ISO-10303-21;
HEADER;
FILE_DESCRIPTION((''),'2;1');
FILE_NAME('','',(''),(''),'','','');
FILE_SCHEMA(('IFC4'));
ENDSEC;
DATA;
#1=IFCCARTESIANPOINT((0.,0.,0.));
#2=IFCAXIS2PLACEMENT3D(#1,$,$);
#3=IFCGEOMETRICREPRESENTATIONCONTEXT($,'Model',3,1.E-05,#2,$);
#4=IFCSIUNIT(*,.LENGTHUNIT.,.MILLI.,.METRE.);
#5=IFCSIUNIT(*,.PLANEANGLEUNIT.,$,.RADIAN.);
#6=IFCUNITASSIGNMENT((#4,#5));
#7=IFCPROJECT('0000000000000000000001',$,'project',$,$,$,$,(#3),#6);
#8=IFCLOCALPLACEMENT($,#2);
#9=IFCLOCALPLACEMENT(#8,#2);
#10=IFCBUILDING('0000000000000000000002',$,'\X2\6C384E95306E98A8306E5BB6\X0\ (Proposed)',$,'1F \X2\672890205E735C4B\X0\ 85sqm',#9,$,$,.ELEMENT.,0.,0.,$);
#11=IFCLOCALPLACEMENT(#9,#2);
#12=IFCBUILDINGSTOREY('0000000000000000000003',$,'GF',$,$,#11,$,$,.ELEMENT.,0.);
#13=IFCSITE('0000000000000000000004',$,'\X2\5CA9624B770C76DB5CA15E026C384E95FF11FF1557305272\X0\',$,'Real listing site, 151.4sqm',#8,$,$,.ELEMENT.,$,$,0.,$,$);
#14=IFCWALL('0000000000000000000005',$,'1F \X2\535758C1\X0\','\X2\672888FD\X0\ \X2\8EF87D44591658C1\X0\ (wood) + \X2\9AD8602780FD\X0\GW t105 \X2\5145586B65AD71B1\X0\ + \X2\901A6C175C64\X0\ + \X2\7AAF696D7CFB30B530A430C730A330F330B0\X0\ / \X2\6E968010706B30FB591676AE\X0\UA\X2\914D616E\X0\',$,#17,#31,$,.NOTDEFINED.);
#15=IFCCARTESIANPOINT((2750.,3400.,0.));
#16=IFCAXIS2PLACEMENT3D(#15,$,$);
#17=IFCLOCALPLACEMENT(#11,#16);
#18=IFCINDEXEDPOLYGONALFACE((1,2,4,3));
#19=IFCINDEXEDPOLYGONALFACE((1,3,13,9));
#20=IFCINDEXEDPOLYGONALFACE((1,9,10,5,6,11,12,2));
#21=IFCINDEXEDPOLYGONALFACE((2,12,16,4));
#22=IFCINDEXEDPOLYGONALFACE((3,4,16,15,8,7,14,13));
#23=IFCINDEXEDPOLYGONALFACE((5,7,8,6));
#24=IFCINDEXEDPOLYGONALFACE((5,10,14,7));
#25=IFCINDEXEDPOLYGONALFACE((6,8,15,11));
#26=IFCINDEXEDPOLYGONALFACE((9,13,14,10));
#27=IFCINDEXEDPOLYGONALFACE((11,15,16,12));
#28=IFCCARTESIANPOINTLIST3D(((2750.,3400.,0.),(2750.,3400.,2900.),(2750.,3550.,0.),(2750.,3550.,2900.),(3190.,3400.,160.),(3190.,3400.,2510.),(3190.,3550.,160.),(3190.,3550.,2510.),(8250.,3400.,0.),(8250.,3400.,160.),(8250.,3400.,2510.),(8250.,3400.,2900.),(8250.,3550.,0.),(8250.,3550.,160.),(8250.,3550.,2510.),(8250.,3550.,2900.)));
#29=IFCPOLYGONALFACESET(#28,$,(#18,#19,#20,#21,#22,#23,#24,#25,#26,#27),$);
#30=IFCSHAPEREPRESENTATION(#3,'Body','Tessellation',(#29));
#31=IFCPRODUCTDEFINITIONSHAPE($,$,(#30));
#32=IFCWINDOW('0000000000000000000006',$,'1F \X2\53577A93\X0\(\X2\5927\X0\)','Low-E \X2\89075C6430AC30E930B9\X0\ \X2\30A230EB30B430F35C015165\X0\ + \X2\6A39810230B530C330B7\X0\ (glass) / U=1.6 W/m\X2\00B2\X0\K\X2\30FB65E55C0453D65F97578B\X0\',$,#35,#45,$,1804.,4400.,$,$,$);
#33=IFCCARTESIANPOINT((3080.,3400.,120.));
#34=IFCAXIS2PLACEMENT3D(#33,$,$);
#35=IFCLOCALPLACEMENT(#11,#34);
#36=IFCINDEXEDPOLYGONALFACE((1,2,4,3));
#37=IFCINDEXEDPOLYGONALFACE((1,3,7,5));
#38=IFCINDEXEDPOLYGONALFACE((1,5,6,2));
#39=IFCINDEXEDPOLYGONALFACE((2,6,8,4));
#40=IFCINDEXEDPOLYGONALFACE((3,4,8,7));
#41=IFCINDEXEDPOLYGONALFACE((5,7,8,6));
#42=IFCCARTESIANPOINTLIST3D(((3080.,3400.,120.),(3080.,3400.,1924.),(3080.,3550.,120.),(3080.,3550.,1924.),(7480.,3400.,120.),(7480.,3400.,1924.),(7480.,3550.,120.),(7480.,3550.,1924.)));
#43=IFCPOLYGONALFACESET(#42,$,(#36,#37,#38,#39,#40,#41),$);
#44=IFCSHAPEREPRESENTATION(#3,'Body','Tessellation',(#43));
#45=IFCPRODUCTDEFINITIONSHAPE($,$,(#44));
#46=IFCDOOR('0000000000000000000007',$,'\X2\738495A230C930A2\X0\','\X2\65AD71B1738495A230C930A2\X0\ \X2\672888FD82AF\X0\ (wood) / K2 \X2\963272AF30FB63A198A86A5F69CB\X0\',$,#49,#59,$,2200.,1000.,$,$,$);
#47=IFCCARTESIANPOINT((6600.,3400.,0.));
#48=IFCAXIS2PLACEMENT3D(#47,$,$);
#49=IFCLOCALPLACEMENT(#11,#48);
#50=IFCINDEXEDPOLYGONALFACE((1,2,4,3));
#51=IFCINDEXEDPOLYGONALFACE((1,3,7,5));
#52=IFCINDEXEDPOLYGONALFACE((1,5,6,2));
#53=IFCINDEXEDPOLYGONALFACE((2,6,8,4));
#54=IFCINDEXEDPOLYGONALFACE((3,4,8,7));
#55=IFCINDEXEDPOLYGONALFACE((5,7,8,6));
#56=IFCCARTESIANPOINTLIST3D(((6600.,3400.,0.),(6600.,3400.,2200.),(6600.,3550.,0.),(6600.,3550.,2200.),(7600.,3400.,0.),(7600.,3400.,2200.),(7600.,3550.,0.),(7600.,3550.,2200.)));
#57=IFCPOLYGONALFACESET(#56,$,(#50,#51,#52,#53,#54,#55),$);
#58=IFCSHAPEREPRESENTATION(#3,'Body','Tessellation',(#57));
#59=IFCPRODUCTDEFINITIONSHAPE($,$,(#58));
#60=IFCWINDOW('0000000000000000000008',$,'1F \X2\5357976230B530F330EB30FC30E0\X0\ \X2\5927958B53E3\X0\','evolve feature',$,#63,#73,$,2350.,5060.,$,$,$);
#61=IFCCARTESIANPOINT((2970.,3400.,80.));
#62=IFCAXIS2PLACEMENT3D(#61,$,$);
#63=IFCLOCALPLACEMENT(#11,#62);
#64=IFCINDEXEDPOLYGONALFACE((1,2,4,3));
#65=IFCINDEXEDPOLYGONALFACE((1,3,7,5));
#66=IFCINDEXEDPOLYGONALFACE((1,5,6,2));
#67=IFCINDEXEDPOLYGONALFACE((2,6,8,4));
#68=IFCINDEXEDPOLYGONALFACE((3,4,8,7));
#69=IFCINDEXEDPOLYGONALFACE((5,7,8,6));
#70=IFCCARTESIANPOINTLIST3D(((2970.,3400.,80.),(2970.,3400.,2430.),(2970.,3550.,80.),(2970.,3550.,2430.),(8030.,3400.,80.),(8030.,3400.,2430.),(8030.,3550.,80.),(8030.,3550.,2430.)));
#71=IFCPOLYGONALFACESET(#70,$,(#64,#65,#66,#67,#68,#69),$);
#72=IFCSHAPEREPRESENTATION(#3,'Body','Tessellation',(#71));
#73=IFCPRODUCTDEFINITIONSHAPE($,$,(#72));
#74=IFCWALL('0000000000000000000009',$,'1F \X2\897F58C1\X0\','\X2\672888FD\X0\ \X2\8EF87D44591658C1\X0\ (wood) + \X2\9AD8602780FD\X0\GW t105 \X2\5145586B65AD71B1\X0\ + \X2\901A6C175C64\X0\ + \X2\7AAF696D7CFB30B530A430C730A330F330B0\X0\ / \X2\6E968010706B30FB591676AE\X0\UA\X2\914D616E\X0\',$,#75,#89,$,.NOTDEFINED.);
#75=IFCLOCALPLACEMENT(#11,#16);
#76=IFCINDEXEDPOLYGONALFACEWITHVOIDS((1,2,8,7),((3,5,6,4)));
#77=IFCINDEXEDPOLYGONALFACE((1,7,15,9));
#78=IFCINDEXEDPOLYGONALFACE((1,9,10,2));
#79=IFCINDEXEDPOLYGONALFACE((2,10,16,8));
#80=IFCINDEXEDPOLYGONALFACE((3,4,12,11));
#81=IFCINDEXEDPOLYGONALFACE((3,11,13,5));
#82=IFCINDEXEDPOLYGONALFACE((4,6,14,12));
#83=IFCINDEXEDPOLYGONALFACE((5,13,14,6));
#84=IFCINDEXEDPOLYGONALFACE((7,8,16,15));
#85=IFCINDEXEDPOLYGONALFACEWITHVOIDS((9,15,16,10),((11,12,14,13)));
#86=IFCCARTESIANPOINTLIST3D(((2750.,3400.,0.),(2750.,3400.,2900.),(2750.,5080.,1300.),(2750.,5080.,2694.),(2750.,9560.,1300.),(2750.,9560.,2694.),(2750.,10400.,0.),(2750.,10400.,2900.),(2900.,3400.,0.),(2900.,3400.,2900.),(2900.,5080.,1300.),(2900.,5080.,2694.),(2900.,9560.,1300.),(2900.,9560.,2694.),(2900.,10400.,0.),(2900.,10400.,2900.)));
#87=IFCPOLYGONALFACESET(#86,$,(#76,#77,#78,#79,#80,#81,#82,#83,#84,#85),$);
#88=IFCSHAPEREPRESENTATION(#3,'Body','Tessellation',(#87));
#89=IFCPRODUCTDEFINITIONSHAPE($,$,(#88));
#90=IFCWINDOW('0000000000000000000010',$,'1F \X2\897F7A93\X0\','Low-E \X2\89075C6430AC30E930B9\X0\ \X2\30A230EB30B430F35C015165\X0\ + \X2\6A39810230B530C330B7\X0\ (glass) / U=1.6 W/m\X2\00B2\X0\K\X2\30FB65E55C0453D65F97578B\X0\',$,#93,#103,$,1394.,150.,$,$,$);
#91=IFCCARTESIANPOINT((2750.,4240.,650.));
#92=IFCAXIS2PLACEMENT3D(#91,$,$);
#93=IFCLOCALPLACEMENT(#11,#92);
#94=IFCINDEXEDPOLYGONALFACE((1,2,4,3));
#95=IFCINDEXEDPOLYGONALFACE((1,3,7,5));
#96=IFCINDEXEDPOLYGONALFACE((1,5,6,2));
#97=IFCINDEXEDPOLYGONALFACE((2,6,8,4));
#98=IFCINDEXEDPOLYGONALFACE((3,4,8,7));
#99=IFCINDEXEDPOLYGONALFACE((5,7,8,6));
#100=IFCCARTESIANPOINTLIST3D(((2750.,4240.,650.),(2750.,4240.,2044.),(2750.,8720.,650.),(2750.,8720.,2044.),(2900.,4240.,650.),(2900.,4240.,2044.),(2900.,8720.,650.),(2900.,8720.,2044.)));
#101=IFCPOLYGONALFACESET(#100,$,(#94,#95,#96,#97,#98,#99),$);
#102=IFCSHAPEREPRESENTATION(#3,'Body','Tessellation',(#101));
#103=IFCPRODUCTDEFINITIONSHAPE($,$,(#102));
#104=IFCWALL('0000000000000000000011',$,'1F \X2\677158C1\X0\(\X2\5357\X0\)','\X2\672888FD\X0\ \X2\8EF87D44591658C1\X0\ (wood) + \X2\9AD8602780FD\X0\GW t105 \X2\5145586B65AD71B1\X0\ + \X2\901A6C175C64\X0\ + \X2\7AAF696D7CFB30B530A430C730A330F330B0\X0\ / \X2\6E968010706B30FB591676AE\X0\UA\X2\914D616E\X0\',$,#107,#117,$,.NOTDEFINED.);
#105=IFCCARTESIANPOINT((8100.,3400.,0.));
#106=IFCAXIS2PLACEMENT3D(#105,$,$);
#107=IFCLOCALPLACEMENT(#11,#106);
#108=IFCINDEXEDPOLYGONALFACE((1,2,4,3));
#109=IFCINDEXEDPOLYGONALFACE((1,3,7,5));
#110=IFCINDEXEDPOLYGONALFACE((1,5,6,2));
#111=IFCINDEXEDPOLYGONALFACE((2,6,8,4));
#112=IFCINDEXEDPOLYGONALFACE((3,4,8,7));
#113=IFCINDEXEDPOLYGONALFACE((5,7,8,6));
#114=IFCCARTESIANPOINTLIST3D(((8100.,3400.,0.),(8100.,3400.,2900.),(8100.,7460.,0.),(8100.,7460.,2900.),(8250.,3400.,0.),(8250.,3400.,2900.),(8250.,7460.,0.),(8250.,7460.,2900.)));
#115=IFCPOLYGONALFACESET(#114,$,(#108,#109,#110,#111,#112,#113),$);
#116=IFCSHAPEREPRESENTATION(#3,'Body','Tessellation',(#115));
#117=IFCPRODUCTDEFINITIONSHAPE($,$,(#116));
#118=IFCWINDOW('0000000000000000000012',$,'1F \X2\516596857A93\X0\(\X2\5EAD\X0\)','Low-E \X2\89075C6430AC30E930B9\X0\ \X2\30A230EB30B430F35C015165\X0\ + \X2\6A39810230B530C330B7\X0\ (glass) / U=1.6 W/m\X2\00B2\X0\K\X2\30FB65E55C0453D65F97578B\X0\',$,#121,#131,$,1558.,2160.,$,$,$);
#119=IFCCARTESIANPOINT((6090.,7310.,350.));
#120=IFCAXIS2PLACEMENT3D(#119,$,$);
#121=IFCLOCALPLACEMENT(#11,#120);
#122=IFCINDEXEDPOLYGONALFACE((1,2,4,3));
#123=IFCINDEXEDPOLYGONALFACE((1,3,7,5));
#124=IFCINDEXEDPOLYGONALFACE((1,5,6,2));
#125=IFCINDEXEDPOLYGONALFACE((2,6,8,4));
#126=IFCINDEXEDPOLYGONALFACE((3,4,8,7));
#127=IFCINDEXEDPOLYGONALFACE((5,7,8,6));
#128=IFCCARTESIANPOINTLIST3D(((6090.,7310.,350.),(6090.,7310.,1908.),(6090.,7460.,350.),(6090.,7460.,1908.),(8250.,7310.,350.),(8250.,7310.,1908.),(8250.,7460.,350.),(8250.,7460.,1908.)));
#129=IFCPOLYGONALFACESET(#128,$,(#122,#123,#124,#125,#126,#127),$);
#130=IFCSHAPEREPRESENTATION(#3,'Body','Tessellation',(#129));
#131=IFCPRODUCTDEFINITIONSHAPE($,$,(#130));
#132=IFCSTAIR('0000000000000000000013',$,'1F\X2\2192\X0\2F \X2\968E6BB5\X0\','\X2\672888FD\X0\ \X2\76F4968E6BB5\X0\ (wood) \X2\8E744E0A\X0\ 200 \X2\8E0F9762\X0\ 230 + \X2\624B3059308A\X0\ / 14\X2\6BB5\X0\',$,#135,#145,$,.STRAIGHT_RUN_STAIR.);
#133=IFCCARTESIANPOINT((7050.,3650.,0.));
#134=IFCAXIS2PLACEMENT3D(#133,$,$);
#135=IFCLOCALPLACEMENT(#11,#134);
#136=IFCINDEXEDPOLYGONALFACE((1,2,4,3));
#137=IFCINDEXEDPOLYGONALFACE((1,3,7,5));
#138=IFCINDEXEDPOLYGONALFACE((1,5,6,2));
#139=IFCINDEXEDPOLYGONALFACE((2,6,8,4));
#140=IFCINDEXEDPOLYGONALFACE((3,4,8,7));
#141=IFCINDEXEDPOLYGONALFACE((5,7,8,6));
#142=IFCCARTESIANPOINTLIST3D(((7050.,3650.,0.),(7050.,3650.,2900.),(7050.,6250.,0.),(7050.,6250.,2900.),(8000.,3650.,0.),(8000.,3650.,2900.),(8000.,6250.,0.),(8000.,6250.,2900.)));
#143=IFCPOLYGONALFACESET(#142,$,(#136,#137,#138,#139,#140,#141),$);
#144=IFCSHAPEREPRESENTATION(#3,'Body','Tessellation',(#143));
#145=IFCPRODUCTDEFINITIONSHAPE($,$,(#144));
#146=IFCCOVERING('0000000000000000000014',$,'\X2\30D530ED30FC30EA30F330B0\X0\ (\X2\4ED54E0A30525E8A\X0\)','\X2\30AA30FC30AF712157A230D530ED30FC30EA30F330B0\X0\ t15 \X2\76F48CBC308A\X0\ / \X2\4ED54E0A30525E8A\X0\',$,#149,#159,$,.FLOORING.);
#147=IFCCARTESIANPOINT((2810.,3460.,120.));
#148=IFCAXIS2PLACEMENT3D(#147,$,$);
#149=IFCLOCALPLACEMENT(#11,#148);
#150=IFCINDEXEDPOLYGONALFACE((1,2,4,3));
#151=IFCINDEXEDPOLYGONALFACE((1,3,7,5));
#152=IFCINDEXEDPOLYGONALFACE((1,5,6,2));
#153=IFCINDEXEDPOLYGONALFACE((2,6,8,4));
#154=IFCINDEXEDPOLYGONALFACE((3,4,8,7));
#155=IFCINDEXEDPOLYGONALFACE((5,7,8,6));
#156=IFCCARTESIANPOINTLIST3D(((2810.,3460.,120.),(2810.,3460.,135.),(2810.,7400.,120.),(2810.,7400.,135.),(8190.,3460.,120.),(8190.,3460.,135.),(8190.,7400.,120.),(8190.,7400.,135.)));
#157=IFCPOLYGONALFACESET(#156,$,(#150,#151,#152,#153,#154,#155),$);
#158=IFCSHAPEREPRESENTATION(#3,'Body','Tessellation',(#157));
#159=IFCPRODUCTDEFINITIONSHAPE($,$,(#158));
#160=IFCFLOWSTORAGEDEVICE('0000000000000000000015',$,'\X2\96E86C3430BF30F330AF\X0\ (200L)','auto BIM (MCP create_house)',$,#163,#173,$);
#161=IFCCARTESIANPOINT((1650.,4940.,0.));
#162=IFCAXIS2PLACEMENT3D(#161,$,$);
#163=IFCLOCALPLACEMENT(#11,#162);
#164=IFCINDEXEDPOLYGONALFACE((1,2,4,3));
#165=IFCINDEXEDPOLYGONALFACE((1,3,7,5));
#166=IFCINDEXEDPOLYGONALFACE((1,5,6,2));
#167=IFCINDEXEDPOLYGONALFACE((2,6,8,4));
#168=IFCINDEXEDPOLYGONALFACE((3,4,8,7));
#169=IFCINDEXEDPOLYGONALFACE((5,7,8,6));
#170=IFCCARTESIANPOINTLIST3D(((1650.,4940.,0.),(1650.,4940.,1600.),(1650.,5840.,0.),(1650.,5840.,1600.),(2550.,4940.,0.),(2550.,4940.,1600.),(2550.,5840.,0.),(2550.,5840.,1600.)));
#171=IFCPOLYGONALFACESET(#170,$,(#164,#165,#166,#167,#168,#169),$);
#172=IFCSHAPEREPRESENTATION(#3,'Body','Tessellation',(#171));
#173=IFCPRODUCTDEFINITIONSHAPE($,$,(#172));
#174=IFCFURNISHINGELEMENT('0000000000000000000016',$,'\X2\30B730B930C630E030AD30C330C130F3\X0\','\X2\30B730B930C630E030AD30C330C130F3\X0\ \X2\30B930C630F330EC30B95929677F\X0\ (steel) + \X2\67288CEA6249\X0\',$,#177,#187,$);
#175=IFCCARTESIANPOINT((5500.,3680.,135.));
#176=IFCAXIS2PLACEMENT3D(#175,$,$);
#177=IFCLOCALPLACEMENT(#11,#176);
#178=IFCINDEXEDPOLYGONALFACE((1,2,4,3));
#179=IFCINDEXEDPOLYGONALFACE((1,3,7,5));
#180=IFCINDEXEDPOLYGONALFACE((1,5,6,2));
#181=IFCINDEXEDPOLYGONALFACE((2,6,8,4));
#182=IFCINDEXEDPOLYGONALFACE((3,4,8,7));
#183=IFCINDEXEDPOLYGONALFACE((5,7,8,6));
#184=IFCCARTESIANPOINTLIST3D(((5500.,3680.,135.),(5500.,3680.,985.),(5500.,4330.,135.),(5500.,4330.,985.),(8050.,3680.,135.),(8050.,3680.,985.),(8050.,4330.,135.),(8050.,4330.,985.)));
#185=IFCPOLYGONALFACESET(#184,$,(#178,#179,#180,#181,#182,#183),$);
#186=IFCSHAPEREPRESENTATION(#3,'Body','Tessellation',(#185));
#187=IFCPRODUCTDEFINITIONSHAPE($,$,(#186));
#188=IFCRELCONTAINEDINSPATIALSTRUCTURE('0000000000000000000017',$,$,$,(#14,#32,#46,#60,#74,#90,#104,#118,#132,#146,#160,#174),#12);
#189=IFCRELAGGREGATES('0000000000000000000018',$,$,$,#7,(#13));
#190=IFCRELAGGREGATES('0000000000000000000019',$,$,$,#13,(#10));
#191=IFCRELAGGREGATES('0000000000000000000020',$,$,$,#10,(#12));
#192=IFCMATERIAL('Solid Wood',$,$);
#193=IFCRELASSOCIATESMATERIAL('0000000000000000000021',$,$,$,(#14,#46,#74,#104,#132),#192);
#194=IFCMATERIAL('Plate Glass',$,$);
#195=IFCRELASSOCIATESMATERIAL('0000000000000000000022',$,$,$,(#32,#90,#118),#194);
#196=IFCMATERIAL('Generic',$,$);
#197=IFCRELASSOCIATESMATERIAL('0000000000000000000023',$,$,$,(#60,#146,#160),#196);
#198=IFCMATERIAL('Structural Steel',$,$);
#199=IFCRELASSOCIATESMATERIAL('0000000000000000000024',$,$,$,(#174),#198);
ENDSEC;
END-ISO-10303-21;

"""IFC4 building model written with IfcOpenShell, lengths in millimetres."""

from ifc_helpers import new_model, si_unit, frame, frame_2d, origin, place, context, project, spatial, rectangle, extrude, material, element, fill, save


model = new_model("IFC4")

# Units and contexts
model_context = context("Model", 3, precision=1e-05, world=origin())
ifc_project = project(units=[si_unit("LENGTHUNIT", "METRE", prefix="MILLI"), si_unit("PLANEANGLEUNIT", "RADIAN")], contexts=[model_context])

# Site, building, storey
site_placement = place(None, origin())
site = spatial("IfcSite", under=ifc_project, at=site_placement, Name="岩手県盛岡市永井１５地割", ObjectType="Real listing site, 151.4sqm", CompositionType="ELEMENT", RefElevation=0.0)
building_placement = place(site_placement, origin())
building = spatial("IfcBuilding", under=site, at=building_placement, Name="永井の風の家 (Proposed)", ObjectType="1F 木造平屋 85sqm", CompositionType="ELEMENT", ElevationOfRefHeight=0.0, ElevationOfTerrain=0.0)
storey_placement = place(building_placement, origin())
storey = spatial("IfcBuildingStorey", under=building, at=storey_placement, Name="GF", CompositionType="ELEMENT", Elevation=0.0)

# Shared definitions
ifc_material_1 = material(Name="Solid Wood")
ifc_material_2 = material(Name="Generic")

# Wall, openings, windows, door
wall_1_placement = place(storey_placement, frame((2750.0, 3400.0, 0.0)))
wall_1 = element("IfcWall", 1, at=wall_1_placement, inside=storey, material=ifc_material_1, Name="1F 南壁", Description="木製 軸組外壁 (wood) + 高性能GW t105 充填断熱 + 通気層 + 窯業系サイディング / 準耐火・外皮UA配慮", PredefinedType="NOTDEFINED", context=model_context, shape_type="SweptSolid", body=[
    extrude(rectangle(XDim=5500.0, YDim=150.0, at=frame_2d((2750.0, 75.0))), frame((2750.0, 3400.0, 0.0)), (0.0, 0.0, 1.0), 2900.0),
])
opening_1_placement = place(storey_placement, frame((3080.0, 3400.0, 120.0)))
opening_1 = element("IfcOpeningElement", 2, at=opening_1_placement, cuts=wall_1, PredefinedType="NOTDEFINED", context=model_context, shape_type="SweptSolid", body=[
    extrude(rectangle(XDim=4400.0, YDim=150.0, at=frame_2d((2200.0, 75.0))), frame((3080.0, 3400.0, 120.0)), (0.0, 0.0, 1.0), 1804.0),
])
opening_2_placement = place(storey_placement, frame((6600.0, 3400.0, 0.0)))
opening_2 = element("IfcOpeningElement", 3, at=opening_2_placement, cuts=wall_1, PredefinedType="NOTDEFINED", context=model_context, shape_type="SweptSolid", body=[
    extrude(rectangle(XDim=1000.0, YDim=150.0, at=frame_2d((500.0, 75.0))), frame((6600.0, 3400.0, 0.0)), (0.0, 0.0, 1.0), 2200.0),
])
opening_3_placement = place(storey_placement, frame((2970.0, 3400.0, 80.0)))
opening_3 = element("IfcOpeningElement", 4, at=opening_3_placement, cuts=wall_1, PredefinedType="NOTDEFINED", context=model_context, shape_type="SweptSolid", body=[
    extrude(rectangle(XDim=5060.0, YDim=150.0, at=frame_2d((2530.0, 75.0))), frame((2970.0, 3400.0, 80.0)), (0.0, 0.0, 1.0), 2350.0),
])
ifc_material_3 = material(Name="Plate Glass")
window_1_placement = place(storey_placement, frame((3080.0, 3400.0, 120.0)))
window_1 = element("IfcWindow", 5, at=window_1_placement, inside=storey, material=ifc_material_3, Name="1F 南窓(大)", Description="Low-E 複層ガラス アルゴン封入 + 樹脂サッシ (glass) / U=1.6 W/m²K・日射取得型", OverallHeight=1804.0, OverallWidth=4400.0, context=model_context, shape_type="SweptSolid", body=[
    extrude(rectangle(XDim=4400.0, YDim=150.0, at=frame_2d((2200.0, 75.0))), frame((3080.0, 3400.0, 120.0)), (0.0, 0.0, 1.0), 1804.0),
])
fill(opening_1, window_1)
door_1_placement = place(storey_placement, frame((6600.0, 3400.0, 0.0)))
door_1 = element("IfcDoor", 6, at=door_1_placement, inside=storey, material=ifc_material_1, Name="玄関ドア", Description="断熱玄関ドア 木製芯 (wood) / K2 防犯・採風機構", OverallHeight=2200.0, OverallWidth=1000.0, context=model_context, shape_type="SweptSolid", body=[
    extrude(rectangle(XDim=1000.0, YDim=150.0, at=frame_2d((500.0, 75.0))), frame((6600.0, 3400.0, 0.0)), (0.0, 0.0, 1.0), 2200.0),
])
fill(opening_2, door_1)
window_2_placement = place(storey_placement, frame((2970.0, 3400.0, 80.0)))
window_2 = element("IfcWindow", 7, at=window_2_placement, inside=storey, material=ifc_material_2, Name="1F 南面サンルーム 大開口", Description="evolve feature", OverallHeight=2350.0, OverallWidth=5060.0, context=model_context, shape_type="SweptSolid", body=[
    extrude(rectangle(XDim=5060.0, YDim=150.0, at=frame_2d((2530.0, 75.0))), frame((2970.0, 3400.0, 80.0)), (0.0, 0.0, 1.0), 2350.0),
])
fill(opening_3, window_2)

# Walls, openings, windows
wall_2_placement = place(storey_placement, frame((2750.0, 3400.0, 0.0)))
wall_2 = element("IfcWall", 8, at=wall_2_placement, inside=storey, material=ifc_material_1, Name="1F 西壁", Description="木製 軸組外壁 (wood) + 高性能GW t105 充填断熱 + 通気層 + 窯業系サイディング / 準耐火・外皮UA配慮", PredefinedType="NOTDEFINED", context=model_context, shape_type="SweptSolid", body=[
    extrude(rectangle(XDim=150.0, YDim=7000.0, at=frame_2d((75.0, 3500.0))), frame((2750.0, 3400.0, 0.0)), (0.0, 0.0, 1.0), 2900.0),
])
opening_4_placement = place(storey_placement, frame((2750.0, 4240.0, 650.0)))
opening_4 = element("IfcOpeningElement", 9, at=opening_4_placement, cuts=wall_2, PredefinedType="NOTDEFINED", context=model_context, shape_type="SweptSolid", body=[
    extrude(rectangle(XDim=150.0, YDim=4480.0, at=frame_2d((75.0, 2240.0))), frame((2750.0, 4240.0, 650.0)), (0.0, 0.0, 1.0), 1394.0),
])
window_3_placement = place(storey_placement, frame((2750.0, 4240.0, 650.0)))
window_3 = element("IfcWindow", 10, at=window_3_placement, inside=storey, material=ifc_material_3, Name="1F 西窓", Description="Low-E 複層ガラス アルゴン封入 + 樹脂サッシ (glass) / U=1.6 W/m²K・日射取得型", OverallHeight=1394.0, OverallWidth=150.0, context=model_context, shape_type="SweptSolid", body=[
    extrude(rectangle(XDim=150.0, YDim=4480.0, at=frame_2d((75.0, 2240.0))), frame((2750.0, 4240.0, 650.0)), (0.0, 0.0, 1.0), 1394.0),
])
fill(opening_4, window_3)
wall_3_placement = place(storey_placement, frame((8100.0, 3400.0, 0.0)))
wall_3 = element("IfcWall", 11, at=wall_3_placement, inside=storey, material=ifc_material_1, Name="1F 東壁(南)", Description="木製 軸組外壁 (wood) + 高性能GW t105 充填断熱 + 通気層 + 窯業系サイディング / 準耐火・外皮UA配慮", PredefinedType="NOTDEFINED", context=model_context, shape_type="SweptSolid", body=[
    extrude(rectangle(XDim=150.0, YDim=4060.0, at=frame_2d((75.0, 2030.0))), frame((8100.0, 3400.0, 0.0)), (0.0, 0.0, 1.0), 2900.0),
])
opening_5_placement = place(storey_placement, frame((6090.0, 7310.0, 350.0)))
opening_5 = element("IfcOpeningElement", 12, at=opening_5_placement, cuts=wall_3, PredefinedType="NOTDEFINED", context=model_context, shape_type="SweptSolid", body=[
    extrude(rectangle(XDim=2160.0, YDim=150.0, at=frame_2d((1080.0, 75.0))), frame((6090.0, 7310.0, 350.0)), (0.0, 0.0, 1.0), 1558.0),
])
window_4_placement = place(storey_placement, frame((6090.0, 7310.0, 350.0)))
window_4 = element("IfcWindow", 13, at=window_4_placement, inside=storey, material=ifc_material_3, Name="1F 入隅窓(庭)", Description="Low-E 複層ガラス アルゴン封入 + 樹脂サッシ (glass) / U=1.6 W/m²K・日射取得型", OverallHeight=1558.0, OverallWidth=2160.0, context=model_context, shape_type="SweptSolid", body=[
    extrude(rectangle(XDim=2160.0, YDim=150.0, at=frame_2d((1080.0, 75.0))), frame((6090.0, 7310.0, 350.0)), (0.0, 0.0, 1.0), 1558.0),
])
fill(opening_5, window_4)

# Stair
stair_placement = place(storey_placement, frame((7050.0, 3650.0, 0.0)))
element("IfcStair", 14, at=stair_placement, inside=storey, material=ifc_material_1, Name="1F→2F 階段", Description="木製 直階段 (wood) 蹴上 200 踏面 230 + 手すり / 14段", PredefinedType="STRAIGHT_RUN_STAIR", context=model_context, shape_type="SweptSolid", body=[
    extrude(rectangle(XDim=950.0, YDim=2600.0, at=frame_2d((475.0, 1300.0))), frame((7050.0, 3650.0, 0.0)), (0.0, 0.0, 1.0), 2900.0),
])

# Covering
covering_placement = place(storey_placement, frame((2810.0, 3460.0, 120.0)))
element("IfcCovering", 15, at=covering_placement, inside=storey, material=ifc_material_2, Name="フローリング (仕上げ床)", Description="オーク無垢フローリング t15 直貼り / 仕上げ床", PredefinedType="FLOORING", context=model_context, shape_type="SweptSolid", body=[
    extrude(rectangle(XDim=5380.0, YDim=3940.0, at=frame_2d((2690.0, 1970.0))), frame((2810.0, 3460.0, 120.0)), (0.0, 0.0, 1.0), 15.0),
])

# Flow storage device
flow_storage_device_placement = place(storey_placement, frame((1650.0, 4940.0, 0.0)))
element("IfcFlowStorageDevice", 16, at=flow_storage_device_placement, inside=storey, material=ifc_material_2, Name="雨水タンク (200L)", Description="auto BIM (MCP create_house)", context=model_context, shape_type="SweptSolid", body=[
    extrude(rectangle(XDim=900.0, YDim=900.0, at=frame_2d((450.0, 450.0))), frame((1650.0, 4940.0, 0.0)), (0.0, 0.0, 1.0), 1600.0),
])

# Furnishing element
ifc_material_4 = material(Name="Structural Steel")
furnishing_placement = place(storey_placement, frame((5500.0, 3680.0, 135.0)))
element("IfcFurnishingElement", 17, at=furnishing_placement, inside=storey, material=ifc_material_4, Name="システムキッチン", Description="システムキッチン ステンレス天板 (steel) + 木質扉", context=model_context, shape_type="SweptSolid", body=[
    extrude(rectangle(XDim=2550.0, YDim=650.0, at=frame_2d((1275.0, 325.0))), frame((5500.0, 3680.0, 135.0)), (0.0, 0.0, 1.0), 850.0),
])

save(model, "model.ifc")
